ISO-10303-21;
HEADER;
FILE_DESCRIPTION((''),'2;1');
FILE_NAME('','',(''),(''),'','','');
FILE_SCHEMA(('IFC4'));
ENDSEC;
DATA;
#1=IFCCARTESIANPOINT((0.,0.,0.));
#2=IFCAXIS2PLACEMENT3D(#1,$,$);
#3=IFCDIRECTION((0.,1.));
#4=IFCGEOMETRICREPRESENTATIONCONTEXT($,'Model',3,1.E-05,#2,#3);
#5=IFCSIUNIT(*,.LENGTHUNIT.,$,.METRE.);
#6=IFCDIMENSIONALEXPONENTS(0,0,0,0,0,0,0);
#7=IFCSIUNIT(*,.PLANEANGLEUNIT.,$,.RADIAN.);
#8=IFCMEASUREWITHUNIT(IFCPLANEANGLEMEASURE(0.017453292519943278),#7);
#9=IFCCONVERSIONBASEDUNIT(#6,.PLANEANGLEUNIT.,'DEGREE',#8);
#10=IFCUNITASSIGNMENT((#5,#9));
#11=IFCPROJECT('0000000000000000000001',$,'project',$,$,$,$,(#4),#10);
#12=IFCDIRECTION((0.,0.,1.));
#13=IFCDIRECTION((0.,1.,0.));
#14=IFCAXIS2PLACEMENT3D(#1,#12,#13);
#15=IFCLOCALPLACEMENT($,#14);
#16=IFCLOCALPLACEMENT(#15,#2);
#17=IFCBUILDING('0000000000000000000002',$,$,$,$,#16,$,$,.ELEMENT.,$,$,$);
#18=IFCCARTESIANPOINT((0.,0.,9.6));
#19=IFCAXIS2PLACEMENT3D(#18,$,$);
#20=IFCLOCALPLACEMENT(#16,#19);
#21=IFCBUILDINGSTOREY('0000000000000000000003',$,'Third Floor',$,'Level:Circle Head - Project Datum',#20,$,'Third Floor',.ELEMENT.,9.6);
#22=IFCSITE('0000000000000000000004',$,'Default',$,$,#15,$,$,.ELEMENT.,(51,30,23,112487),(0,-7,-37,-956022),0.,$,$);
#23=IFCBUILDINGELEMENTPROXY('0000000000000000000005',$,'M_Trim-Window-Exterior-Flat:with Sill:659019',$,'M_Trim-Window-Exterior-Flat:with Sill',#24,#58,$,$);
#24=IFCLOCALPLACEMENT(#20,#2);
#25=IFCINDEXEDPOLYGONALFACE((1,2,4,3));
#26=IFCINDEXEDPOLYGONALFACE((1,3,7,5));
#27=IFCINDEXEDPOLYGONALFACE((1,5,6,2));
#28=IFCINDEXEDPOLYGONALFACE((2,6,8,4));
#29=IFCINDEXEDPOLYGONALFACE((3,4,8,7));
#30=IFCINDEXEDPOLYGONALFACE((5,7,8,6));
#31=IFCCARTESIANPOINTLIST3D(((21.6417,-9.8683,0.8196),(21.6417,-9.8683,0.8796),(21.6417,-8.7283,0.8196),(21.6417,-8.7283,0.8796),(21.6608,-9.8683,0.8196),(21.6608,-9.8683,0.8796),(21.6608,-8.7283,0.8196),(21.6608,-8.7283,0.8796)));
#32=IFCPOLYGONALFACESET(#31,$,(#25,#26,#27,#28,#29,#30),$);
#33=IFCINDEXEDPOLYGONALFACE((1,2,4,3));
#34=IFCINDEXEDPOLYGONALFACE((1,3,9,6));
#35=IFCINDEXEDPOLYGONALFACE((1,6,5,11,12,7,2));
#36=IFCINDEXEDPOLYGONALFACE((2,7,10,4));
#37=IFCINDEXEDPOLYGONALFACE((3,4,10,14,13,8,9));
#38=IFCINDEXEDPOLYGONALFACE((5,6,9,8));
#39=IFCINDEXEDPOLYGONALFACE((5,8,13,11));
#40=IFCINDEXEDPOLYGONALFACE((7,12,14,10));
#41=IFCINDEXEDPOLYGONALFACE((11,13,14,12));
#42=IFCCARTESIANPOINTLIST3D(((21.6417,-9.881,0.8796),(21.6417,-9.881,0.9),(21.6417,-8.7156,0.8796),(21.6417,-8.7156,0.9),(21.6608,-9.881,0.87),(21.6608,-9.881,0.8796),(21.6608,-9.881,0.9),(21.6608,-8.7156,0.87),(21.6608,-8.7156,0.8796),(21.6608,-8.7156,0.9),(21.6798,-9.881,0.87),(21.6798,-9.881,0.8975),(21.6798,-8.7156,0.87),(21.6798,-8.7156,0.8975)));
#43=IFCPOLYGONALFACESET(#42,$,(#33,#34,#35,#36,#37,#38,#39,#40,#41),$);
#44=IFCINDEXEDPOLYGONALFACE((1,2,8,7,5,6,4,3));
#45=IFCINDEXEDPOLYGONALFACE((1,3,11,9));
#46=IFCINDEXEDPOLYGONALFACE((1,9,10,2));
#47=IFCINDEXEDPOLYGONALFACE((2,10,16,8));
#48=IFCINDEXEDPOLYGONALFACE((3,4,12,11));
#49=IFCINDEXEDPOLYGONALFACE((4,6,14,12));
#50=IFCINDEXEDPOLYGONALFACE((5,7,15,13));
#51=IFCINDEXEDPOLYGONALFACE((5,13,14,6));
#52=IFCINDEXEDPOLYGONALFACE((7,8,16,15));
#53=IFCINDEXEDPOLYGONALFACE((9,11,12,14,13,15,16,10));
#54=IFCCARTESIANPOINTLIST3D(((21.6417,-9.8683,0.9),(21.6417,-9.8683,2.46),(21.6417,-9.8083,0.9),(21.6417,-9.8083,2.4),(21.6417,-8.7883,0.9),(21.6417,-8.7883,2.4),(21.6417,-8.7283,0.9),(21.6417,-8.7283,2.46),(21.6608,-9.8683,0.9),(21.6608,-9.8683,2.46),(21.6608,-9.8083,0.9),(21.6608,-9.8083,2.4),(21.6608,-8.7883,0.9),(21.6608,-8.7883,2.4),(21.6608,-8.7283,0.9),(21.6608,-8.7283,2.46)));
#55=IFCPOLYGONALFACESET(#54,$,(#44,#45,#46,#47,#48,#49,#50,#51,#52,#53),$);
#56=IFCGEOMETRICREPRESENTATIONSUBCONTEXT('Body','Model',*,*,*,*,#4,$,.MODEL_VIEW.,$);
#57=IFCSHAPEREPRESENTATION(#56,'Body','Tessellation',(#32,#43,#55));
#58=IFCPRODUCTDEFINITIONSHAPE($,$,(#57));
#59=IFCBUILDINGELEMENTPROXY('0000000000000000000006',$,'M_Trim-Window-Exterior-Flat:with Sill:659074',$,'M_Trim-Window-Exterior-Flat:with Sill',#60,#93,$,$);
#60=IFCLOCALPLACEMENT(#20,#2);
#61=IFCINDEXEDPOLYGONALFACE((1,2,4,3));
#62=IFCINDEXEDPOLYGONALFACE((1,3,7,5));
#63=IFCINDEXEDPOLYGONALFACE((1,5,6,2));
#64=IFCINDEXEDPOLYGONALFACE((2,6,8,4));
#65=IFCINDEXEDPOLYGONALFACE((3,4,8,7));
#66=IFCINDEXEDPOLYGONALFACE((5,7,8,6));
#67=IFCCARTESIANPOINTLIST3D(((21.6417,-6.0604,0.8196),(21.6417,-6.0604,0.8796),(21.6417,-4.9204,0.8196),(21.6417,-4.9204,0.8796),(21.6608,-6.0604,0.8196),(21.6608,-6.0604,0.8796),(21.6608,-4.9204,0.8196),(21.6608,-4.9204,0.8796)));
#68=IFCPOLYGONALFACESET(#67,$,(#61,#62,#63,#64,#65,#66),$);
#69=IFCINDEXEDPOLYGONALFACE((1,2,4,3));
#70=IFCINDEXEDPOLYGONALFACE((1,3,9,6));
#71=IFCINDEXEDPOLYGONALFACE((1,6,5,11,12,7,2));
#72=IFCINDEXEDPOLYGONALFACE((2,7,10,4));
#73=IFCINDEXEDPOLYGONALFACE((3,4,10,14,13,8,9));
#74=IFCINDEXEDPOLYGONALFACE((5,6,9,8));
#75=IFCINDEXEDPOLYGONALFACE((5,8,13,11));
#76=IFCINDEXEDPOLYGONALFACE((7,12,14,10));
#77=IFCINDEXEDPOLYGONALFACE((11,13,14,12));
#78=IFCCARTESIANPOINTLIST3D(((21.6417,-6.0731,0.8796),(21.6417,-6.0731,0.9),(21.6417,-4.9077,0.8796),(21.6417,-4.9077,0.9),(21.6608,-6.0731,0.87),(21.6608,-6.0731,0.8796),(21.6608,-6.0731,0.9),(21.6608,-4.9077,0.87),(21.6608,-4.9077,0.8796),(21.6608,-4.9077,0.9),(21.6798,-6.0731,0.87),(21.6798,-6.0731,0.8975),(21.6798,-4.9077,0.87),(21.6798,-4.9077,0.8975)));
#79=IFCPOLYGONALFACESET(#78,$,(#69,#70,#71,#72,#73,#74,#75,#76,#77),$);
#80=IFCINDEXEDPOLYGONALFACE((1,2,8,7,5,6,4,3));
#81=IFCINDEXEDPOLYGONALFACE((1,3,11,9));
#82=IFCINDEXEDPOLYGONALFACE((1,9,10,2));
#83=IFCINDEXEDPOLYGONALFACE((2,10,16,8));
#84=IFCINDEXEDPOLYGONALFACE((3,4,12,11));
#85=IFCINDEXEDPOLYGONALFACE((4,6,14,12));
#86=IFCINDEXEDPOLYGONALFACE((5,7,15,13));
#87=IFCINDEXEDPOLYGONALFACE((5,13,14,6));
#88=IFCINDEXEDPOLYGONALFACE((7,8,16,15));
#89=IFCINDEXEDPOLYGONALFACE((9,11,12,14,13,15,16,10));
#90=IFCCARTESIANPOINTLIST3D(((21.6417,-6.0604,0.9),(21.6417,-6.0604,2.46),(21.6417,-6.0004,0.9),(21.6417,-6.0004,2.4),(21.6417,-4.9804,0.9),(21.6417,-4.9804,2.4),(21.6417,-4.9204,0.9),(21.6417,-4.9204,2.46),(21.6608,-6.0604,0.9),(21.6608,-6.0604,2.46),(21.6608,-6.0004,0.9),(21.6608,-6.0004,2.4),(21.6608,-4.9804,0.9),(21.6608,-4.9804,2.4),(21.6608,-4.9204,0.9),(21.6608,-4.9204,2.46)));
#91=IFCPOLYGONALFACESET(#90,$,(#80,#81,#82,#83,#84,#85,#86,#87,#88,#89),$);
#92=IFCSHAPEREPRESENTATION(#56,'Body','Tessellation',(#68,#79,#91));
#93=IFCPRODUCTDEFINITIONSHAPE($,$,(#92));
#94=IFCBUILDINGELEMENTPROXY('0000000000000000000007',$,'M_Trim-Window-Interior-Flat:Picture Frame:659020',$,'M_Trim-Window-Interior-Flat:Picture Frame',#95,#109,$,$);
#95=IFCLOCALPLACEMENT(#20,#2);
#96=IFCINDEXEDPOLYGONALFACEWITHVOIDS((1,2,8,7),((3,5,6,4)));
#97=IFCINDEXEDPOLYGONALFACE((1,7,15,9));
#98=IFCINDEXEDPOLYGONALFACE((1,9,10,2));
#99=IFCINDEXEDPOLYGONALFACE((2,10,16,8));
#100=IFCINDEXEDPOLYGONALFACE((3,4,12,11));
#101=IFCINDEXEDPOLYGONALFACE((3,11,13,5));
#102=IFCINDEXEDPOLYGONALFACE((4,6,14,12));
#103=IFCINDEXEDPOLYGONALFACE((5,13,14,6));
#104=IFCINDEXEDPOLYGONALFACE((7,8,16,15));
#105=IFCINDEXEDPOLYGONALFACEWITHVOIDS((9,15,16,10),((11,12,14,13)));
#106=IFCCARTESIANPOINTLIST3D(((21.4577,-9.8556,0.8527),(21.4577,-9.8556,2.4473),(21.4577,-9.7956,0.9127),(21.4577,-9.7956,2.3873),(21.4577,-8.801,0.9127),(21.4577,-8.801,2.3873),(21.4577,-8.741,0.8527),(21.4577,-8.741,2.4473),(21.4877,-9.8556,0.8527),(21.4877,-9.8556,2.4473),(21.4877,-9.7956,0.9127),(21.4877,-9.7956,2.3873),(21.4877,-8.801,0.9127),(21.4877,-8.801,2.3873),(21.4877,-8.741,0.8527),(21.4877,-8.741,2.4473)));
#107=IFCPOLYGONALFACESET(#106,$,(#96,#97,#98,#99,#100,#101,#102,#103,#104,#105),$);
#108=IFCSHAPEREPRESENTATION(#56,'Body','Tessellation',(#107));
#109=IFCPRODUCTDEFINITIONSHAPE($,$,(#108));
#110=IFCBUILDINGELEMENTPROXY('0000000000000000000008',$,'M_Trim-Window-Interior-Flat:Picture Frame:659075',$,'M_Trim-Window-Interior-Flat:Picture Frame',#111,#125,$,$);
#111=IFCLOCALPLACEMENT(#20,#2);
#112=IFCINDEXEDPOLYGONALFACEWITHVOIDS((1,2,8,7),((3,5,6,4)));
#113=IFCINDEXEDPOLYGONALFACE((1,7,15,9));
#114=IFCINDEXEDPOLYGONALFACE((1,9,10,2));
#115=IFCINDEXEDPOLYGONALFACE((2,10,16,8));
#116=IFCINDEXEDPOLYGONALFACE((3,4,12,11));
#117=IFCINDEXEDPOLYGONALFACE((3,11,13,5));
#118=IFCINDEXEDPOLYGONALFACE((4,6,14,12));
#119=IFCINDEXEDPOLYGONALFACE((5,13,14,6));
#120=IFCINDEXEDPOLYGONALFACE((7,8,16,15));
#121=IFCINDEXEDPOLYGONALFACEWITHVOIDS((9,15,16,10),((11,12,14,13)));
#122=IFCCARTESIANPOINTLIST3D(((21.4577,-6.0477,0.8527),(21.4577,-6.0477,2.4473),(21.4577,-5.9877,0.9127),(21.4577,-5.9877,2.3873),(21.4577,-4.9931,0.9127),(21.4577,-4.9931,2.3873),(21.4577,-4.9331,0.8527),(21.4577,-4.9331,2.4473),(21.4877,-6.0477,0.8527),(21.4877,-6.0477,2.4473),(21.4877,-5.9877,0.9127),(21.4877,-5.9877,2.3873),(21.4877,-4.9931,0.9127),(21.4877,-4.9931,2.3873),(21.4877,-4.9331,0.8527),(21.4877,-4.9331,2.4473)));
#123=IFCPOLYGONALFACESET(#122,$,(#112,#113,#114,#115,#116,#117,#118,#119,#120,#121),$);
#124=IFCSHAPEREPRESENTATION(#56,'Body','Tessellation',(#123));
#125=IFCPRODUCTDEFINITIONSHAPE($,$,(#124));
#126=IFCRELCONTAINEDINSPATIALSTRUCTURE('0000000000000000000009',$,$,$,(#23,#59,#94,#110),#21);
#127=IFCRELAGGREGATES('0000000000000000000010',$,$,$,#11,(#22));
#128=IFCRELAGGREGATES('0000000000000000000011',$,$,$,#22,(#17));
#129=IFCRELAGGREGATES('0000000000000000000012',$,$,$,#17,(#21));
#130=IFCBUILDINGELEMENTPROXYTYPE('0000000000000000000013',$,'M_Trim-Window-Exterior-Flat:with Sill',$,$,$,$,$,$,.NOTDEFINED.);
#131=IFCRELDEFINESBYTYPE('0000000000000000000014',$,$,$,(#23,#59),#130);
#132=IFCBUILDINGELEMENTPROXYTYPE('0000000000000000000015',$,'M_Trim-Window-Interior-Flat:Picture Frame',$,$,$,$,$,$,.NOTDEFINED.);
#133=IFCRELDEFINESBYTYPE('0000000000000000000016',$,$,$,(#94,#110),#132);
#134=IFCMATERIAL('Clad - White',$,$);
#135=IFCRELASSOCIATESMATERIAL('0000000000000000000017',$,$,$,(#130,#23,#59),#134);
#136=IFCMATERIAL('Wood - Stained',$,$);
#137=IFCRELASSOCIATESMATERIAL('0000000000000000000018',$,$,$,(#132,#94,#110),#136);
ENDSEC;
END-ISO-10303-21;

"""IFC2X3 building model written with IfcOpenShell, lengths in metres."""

from ifc_helpers import new_model, entity, si_unit, converted_unit, direction, frame, frame_2d, origin, place, context, subcontext, project, spatial, polyline, rectangle, outline, extrude, source, transform, mapped, material, type_object, type_shapes, element, save


model = new_model("IFC2X3")

# Units and contexts
model_context = context("Model", 3, precision=1e-05, world=origin(), true_north=direction((0.0, 1.0)))
body_context = subcontext(model_context, "Body", "Model", "MODEL_VIEW")
ifc_project = project(units=[si_unit("LENGTHUNIT", "METRE"), converted_unit("PLANEANGLEUNIT", "DEGREE", entity("IfcPlaneAngleMeasure", 0.017453292519943278), si_unit("PLANEANGLEUNIT", "RADIAN"), dimensions=[0, 0, 0, 0, 0, 0, 0])], contexts=[model_context])

# Site, building, storey
site_placement = place(None, frame((0.0, 0.0, 0.0), z_axis=(0.0, 0.0, 1.0), x_axis=(0.0, 1.0, 0.0)))
site = spatial("IfcSite", under=ifc_project, at=site_placement, Name="Default", CompositionType="ELEMENT", RefLatitude=(51, 30, 23, 112487), RefLongitude=(0, -7, -37, -956022), RefElevation=0.0)
building_placement = place(site_placement, origin())
building = spatial("IfcBuilding", under=site, at=building_placement, CompositionType="ELEMENT")
storey_placement = place(building_placement, frame((0.0, 0.0, 9.6)))
storey = spatial("IfcBuildingStorey", under=building, at=storey_placement, Name="Third Floor", ObjectType="Level:Circle Head - Project Datum", LongName="Third Floor", CompositionType="ELEMENT", Elevation=9.6)

# Building element proxies
ifc_material_1 = material(Name="Clad - White")
ifc_material_2 = material(Name="Wood - Stained")
building_element_proxy_type_1 = type_object("IfcBuildingElementProxyType", Name="M_Trim-Window-Exterior-Flat:with Sill", PredefinedType="NOTDEFINED", material=ifc_material_1)
shared_shape_1 = source(origin(), body_context, "Body", "SweptSolid", [
    extrude(rectangle(XDim=1.14, YDim=0.06, at=frame_2d((0.0, 0.0), x_axis=(1.0, 0.0))), frame((0.0, -1.5504, 0.0), z_axis=(0.0, 0.0, 1.0), x_axis=(-1.0, 0.0, 0.0)), (0.0, 0.0, 1.0), 0.019),
    extrude(outline(polyline([(-0.019, -0.0152), (0.0, -0.0152), (0.0, -0.0057), (0.019, -0.0057), (0.019, 0.0148), (0.0, 0.0148), (-0.019, 0.0123), (-0.019, -0.0152)])), frame((-0.5827, -1.5148, 0.019), z_axis=(1.0, 0.0, 0.0), x_axis=(0.0, 0.0, -1.0)), (0.0, 0.0, 1.0), 1.1654),
    extrude(outline(polyline([(-0.795, -0.57), (0.765, -0.57), (0.765, -0.51), (-0.735, -0.51), (-0.735, 0.51), (0.765, 0.51), (0.765, 0.57), (-0.795, 0.57), (-0.795, -0.57)])), frame((0.0, -0.735, 0.0), z_axis=(0.0, 0.0, 1.0), x_axis=(0.0, -1.0, 0.0)), (0.0, 0.0, 1.0), 0.019),
])
type_shapes(building_element_proxy_type_1, [shared_shape_1])
for number, where, z_axis, x_axis, name in (
    (1, (21.6417, -9.2983, 2.4), (1.0, 0.0, 0.0), (0.0, 1.0, 0.0), "M_Trim-Window-Exterior-Flat:with Sill:659019"),
    (2, (21.6417, -5.4904, 2.4), (1.0, 0.0, 0.0), (0.0, 1.0, 0.0), "M_Trim-Window-Exterior-Flat:with Sill:659074"),
):
    element("IfcBuildingElementProxy", number, at=place(storey_placement, frame(where, z_axis=z_axis, x_axis=x_axis)), inside=storey, type_object=building_element_proxy_type_1, material=ifc_material_1, Name=name, ObjectType="M_Trim-Window-Exterior-Flat:with Sill", context=body_context, shape_type="MappedRepresentation", body=[
        mapped(shared_shape_1, transform((0.0, 0.0, 0.0), scale=1.0)),
    ])
building_element_proxy_type_2 = type_object("IfcBuildingElementProxyType", Name="M_Trim-Window-Interior-Flat:Picture Frame", PredefinedType="NOTDEFINED", material=ifc_material_2)
shared_shape_2 = source(origin(), body_context, "Body", "SweptSolid", [
    extrude(outline(polyline([(-0.5573, -0.7973), (0.5573, -0.7973), (0.5573, 0.7973), (-0.5573, 0.7973), (-0.5573, -0.7973)]), holes=[polyline([(-0.4973, -0.7373), (-0.4973, 0.7373), (0.4973, 0.7373), (0.4973, -0.7373), (-0.4973, -0.7373)])]), frame((0.0, -0.75, 0.0), z_axis=(0.0, 0.0, 1.0), x_axis=(-1.0, 0.0, 0.0)), (0.0, 0.0, 1.0), 0.03),
])
type_shapes(building_element_proxy_type_2, [shared_shape_2])
for number, where, z_axis, x_axis, name in (
    (3, (21.4877, -9.2983, 2.4), (-1.0, 0.0, 0.0), (0.0, -1.0, 0.0), "M_Trim-Window-Interior-Flat:Picture Frame:659020"),
    (4, (21.4877, -5.4904, 2.4), (-1.0, 0.0, 0.0), (0.0, -1.0, 0.0), "M_Trim-Window-Interior-Flat:Picture Frame:659075"),
):
    element("IfcBuildingElementProxy", number, at=place(storey_placement, frame(where, z_axis=z_axis, x_axis=x_axis)), inside=storey, type_object=building_element_proxy_type_2, material=ifc_material_2, Name=name, ObjectType="M_Trim-Window-Interior-Flat:Picture Frame", context=body_context, shape_type="MappedRepresentation", body=[
        mapped(shared_shape_2, transform((0.0, 0.0, 0.0), scale=1.0)),
    ])

save(model, "model.ifc")
